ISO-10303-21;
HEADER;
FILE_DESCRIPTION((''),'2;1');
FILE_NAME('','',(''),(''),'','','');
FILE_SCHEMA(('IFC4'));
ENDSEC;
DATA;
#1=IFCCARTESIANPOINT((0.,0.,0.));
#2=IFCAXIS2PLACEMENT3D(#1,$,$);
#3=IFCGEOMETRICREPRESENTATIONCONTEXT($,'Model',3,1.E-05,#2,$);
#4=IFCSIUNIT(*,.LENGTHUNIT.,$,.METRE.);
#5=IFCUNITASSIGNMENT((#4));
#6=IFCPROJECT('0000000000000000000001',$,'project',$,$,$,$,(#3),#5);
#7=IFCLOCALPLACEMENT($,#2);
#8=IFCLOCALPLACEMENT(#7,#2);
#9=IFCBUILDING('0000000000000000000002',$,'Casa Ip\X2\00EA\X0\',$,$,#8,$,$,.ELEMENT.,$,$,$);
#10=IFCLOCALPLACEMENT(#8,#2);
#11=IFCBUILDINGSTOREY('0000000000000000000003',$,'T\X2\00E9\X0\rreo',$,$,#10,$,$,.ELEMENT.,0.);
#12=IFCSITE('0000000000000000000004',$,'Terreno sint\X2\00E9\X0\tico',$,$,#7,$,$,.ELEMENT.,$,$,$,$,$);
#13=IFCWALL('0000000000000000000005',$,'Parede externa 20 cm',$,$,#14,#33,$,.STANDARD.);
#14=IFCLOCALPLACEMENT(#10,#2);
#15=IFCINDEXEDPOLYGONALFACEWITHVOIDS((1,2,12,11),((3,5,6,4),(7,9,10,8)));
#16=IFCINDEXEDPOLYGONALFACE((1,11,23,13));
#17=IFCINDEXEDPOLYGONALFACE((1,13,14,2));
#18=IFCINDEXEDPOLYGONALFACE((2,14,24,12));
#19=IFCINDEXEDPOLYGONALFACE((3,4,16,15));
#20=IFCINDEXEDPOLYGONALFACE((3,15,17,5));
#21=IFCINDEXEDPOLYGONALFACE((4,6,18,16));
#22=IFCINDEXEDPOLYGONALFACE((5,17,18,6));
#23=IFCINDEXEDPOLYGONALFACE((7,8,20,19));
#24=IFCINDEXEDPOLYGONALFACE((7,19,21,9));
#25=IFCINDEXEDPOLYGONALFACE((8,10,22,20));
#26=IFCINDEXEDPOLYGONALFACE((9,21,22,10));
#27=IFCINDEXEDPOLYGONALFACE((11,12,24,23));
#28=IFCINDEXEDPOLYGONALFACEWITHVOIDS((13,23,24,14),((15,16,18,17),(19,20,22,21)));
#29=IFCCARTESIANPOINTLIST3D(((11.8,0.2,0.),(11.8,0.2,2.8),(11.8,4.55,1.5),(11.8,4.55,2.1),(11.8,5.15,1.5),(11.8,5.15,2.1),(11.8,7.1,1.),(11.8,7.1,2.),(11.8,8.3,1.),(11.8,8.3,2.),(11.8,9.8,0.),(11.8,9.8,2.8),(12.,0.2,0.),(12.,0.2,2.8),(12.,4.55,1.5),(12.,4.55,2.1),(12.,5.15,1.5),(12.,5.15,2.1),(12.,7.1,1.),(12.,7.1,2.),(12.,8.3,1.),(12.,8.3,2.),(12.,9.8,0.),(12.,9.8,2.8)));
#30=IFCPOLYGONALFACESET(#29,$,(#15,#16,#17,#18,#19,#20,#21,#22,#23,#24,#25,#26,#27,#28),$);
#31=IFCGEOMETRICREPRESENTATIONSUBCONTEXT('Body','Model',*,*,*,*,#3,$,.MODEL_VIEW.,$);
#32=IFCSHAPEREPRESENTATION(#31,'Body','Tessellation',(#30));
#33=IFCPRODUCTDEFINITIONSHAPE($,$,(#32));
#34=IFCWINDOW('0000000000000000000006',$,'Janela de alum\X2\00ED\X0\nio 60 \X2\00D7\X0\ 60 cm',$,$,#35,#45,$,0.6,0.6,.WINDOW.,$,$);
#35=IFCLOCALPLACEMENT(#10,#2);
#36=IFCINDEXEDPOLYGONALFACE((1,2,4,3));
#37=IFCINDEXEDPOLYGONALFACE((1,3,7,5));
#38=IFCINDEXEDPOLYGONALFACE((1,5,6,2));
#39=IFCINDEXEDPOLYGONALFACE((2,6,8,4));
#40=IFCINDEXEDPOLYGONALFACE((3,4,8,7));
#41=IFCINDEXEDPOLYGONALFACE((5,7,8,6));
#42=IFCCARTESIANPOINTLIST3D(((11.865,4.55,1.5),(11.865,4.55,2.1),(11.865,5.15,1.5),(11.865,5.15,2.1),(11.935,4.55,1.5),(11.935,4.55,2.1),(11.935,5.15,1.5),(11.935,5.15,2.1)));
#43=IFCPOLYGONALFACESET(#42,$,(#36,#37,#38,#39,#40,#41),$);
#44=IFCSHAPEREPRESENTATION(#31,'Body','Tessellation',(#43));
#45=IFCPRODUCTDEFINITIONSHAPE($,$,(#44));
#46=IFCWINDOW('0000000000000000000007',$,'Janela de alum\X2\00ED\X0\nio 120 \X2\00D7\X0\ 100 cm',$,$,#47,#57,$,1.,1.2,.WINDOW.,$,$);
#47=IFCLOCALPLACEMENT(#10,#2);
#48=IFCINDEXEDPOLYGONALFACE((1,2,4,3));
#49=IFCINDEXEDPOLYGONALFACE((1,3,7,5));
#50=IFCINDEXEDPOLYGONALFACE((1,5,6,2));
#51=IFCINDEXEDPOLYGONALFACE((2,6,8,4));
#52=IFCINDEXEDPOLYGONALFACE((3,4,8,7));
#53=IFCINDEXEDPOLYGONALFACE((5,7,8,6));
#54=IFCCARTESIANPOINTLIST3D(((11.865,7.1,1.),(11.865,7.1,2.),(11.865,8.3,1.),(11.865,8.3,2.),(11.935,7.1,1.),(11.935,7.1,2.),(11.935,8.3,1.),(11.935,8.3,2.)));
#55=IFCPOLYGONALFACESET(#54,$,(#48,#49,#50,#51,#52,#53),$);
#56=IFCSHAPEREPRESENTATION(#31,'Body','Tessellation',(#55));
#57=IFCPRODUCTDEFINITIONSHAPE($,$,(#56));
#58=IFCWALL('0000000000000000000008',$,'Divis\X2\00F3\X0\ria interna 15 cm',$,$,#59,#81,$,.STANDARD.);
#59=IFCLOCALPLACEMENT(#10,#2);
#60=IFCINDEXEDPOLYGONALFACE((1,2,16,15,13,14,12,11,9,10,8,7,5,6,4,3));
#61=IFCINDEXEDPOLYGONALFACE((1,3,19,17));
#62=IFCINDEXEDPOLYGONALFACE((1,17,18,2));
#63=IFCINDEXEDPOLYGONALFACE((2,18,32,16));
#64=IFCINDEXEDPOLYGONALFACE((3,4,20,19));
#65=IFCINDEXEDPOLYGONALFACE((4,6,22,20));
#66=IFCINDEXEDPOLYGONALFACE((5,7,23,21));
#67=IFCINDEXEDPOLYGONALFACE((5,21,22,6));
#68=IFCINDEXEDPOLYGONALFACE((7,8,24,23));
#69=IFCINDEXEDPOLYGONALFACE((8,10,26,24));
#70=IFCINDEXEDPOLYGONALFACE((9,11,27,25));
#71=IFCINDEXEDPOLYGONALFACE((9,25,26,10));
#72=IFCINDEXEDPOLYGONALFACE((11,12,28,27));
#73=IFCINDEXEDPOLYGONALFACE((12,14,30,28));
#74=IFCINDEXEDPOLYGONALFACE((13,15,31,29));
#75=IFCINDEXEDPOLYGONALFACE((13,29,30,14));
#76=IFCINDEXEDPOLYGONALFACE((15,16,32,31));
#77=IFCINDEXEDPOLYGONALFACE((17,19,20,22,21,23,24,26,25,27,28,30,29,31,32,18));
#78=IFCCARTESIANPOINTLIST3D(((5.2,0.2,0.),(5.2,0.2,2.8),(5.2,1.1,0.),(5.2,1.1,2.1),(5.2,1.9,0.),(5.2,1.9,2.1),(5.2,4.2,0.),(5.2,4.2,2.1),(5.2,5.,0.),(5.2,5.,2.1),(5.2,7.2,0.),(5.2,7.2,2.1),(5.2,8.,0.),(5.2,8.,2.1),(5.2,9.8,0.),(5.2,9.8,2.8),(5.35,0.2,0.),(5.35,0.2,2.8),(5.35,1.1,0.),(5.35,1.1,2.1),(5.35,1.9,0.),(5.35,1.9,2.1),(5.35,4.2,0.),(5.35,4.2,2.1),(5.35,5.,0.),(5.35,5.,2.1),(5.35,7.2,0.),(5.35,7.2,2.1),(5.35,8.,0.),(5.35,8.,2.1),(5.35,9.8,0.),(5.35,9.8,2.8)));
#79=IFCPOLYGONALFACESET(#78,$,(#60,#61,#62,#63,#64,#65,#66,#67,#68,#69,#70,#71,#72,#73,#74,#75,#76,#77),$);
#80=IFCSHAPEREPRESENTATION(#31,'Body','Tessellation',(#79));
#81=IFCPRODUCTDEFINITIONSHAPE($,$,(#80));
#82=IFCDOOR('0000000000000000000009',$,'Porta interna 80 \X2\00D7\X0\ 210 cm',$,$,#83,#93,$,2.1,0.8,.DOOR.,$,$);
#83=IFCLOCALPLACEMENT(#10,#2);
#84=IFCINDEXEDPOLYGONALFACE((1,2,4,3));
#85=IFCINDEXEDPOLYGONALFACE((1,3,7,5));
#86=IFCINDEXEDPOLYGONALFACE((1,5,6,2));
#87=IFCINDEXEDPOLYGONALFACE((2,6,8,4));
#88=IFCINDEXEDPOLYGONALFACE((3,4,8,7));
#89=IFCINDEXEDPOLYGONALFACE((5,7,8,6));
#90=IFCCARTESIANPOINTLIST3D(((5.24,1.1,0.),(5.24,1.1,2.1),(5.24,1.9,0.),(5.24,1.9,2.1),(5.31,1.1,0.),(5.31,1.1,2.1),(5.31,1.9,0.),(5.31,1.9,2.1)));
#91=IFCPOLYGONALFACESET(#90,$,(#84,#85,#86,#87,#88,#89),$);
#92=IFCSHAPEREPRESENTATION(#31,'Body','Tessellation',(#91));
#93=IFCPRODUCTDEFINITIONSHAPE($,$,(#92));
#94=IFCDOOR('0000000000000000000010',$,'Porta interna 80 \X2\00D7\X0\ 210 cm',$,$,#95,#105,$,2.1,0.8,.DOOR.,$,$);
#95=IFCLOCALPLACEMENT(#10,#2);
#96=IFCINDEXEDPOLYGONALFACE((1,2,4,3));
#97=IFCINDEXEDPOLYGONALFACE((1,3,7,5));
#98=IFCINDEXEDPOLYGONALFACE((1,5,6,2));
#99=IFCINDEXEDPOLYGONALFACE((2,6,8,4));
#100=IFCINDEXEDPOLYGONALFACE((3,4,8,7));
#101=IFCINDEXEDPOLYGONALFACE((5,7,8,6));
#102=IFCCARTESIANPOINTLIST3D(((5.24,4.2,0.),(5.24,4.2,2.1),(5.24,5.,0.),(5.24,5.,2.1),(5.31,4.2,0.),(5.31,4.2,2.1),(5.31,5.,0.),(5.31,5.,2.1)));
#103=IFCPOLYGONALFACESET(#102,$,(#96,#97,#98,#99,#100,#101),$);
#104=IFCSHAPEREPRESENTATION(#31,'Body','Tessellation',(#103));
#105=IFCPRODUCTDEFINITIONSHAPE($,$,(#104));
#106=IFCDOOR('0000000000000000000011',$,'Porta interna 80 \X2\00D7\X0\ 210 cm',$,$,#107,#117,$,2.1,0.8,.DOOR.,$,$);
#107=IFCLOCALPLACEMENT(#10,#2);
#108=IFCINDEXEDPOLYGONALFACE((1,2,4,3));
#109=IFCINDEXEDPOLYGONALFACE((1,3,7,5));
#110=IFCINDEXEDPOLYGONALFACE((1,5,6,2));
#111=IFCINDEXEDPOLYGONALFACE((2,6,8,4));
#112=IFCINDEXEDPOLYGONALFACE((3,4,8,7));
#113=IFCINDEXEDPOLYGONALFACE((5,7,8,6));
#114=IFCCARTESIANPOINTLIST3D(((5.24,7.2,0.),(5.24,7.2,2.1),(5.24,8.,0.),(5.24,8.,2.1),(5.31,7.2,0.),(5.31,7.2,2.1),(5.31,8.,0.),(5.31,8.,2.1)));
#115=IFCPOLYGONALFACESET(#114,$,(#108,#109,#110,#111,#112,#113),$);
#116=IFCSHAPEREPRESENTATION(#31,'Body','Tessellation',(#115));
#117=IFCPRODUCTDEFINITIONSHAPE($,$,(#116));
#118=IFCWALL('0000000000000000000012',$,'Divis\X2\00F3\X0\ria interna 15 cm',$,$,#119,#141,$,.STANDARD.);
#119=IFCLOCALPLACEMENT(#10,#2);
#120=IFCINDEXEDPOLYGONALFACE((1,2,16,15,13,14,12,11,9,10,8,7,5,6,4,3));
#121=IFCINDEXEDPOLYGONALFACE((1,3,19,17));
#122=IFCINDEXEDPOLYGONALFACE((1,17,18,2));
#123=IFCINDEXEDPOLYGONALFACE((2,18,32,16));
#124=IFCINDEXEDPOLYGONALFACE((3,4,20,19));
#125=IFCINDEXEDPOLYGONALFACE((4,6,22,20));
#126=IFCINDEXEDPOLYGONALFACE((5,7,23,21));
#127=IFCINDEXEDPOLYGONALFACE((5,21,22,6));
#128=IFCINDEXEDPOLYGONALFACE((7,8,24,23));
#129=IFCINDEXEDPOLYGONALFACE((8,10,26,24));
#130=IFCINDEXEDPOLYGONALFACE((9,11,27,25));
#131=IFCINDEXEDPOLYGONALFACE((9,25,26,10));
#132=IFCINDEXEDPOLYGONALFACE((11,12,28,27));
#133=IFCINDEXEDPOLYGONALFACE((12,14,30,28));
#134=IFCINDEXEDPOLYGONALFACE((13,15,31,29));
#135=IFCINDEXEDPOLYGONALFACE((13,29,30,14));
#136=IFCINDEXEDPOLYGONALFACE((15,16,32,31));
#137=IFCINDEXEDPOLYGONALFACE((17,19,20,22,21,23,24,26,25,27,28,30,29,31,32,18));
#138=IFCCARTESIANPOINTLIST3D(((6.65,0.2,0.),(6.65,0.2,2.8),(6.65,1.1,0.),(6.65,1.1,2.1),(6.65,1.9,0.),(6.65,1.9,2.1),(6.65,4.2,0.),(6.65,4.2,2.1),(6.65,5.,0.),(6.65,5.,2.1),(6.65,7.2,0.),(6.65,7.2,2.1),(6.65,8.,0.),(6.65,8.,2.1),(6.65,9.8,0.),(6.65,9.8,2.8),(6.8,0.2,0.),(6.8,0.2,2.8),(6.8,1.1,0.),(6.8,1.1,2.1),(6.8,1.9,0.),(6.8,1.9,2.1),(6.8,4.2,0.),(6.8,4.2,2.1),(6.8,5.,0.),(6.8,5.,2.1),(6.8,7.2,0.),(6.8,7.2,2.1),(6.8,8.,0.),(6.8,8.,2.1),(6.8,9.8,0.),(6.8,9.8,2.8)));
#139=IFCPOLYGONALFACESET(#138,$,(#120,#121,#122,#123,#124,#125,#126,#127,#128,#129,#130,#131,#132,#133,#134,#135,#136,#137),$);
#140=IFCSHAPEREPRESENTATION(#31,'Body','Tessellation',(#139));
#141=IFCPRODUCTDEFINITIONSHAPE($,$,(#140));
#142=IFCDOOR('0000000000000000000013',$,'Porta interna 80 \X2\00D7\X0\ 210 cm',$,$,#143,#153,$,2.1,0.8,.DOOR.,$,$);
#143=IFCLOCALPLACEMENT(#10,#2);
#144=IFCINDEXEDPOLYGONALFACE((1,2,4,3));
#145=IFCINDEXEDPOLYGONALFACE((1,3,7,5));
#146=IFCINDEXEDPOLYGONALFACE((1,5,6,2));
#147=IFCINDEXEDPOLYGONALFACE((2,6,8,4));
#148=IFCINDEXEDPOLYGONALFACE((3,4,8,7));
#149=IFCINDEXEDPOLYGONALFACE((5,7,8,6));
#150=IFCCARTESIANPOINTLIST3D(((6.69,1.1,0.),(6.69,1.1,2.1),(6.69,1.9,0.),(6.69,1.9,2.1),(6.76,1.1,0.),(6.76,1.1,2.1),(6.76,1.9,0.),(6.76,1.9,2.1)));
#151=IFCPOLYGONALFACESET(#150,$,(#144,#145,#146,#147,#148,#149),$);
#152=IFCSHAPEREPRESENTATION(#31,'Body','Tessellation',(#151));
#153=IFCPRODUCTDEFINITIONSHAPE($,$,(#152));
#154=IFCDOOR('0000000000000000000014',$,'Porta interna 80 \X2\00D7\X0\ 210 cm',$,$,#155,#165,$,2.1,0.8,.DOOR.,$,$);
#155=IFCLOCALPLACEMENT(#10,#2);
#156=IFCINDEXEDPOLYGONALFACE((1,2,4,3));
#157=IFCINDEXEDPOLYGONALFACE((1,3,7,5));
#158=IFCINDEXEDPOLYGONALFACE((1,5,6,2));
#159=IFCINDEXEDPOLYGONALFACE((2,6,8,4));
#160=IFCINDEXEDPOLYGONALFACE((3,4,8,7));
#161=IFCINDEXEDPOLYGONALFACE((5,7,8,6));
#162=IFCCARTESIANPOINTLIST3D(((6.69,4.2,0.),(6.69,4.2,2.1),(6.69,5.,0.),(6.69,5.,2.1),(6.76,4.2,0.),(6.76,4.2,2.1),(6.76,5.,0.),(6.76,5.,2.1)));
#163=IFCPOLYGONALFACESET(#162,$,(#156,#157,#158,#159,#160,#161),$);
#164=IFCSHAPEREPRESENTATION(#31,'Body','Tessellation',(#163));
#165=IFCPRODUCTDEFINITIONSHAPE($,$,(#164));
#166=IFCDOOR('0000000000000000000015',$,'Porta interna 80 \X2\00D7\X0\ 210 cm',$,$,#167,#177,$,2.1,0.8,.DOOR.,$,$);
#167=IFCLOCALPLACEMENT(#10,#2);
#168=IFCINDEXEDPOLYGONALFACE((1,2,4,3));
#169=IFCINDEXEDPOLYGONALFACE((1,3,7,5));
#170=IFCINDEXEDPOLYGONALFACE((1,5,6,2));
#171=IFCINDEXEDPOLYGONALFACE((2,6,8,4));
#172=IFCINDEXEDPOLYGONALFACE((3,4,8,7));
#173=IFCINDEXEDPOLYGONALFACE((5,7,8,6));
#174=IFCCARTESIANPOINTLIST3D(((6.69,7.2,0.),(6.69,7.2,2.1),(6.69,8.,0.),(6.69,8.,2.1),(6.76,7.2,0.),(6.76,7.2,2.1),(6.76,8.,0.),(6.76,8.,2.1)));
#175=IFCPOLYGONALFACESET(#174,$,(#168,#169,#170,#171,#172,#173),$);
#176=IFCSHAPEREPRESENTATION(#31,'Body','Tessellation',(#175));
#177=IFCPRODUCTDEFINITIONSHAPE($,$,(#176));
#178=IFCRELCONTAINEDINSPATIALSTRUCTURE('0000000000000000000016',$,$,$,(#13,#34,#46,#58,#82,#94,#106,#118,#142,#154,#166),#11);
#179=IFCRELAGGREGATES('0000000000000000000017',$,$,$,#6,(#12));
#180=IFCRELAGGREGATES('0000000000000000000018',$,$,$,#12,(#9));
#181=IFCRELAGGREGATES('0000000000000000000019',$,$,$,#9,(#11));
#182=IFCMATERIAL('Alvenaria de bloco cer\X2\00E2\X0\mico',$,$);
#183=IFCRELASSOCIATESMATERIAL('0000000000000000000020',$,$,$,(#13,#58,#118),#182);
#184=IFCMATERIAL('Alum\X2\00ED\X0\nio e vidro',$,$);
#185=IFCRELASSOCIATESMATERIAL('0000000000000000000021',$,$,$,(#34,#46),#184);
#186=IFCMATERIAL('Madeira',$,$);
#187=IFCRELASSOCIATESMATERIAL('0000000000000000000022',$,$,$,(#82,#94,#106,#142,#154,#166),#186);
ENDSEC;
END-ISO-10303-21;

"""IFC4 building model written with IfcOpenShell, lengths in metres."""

from ifc_helpers import new_model, si_unit, frame, frame_2d, origin, place, context, subcontext, project, spatial, rectangle, extrude, material, element, fill, save


model = new_model("IFC4")

# Units and contexts
model_context = context("Model", 3, precision=1e-05, world=origin())
body_context = subcontext(model_context, "Body", "Model", "MODEL_VIEW")
ifc_project = project(units=[si_unit("LENGTHUNIT", "METRE")], contexts=[model_context])

# Site, building, storey
site_placement = place(None, origin())
site = spatial("IfcSite", under=ifc_project, at=site_placement, Name="Terreno sintético", CompositionType="ELEMENT")
building_placement = place(site_placement, origin())
building = spatial("IfcBuilding", under=site, at=building_placement, Name="Casa Ipê", CompositionType="ELEMENT")
storey_placement = place(building_placement, origin())
storey = spatial("IfcBuildingStorey", under=building, at=storey_placement, Name="Térreo", CompositionType="ELEMENT", Elevation=0.0)

# Wall, openings, windows
ifc_material_1 = material(Name="Alvenaria de bloco cerâmico")
wall_1_placement = place(storey_placement, frame((11.8, 0.2, 0.0)))
wall_1 = element("IfcWall", 1, at=wall_1_placement, inside=storey, material=ifc_material_1, Name="Parede externa 20 cm", PredefinedType="STANDARD", context=body_context, shape_type="SweptSolid", body=[
    extrude(rectangle(XDim=0.2, YDim=9.6, at=frame_2d((0.1, 4.8))), origin(), (0.0, 0.0, 1.0), 2.8),
])
opening_1_placement = place(wall_1_placement, frame((-0.01, 4.35, 1.5)))
opening_1 = element("IfcOpeningElement", 2, at=opening_1_placement, cuts=wall_1, PredefinedType="OPENING", context=body_context, shape_type="SweptSolid", body=[
    extrude(rectangle(XDim=0.22, YDim=0.6, at=frame_2d((0.11, 0.3))), origin(), (0.0, 0.0, 1.0), 0.6),
])
opening_2_placement = place(wall_1_placement, frame((-0.01, 6.9, 1.0)))
opening_2 = element("IfcOpeningElement", 3, at=opening_2_placement, cuts=wall_1, PredefinedType="OPENING", context=body_context, shape_type="SweptSolid", body=[
    extrude(rectangle(XDim=0.22, YDim=1.2, at=frame_2d((0.11, 0.6))), origin(), (0.0, 0.0, 1.0), 1.0),
])
ifc_material_2 = material(Name="Alumínio e vidro")
window_1_placement = place(storey_placement, frame((11.865, 4.55, 1.5)))
window_1 = element("IfcWindow", 4, at=window_1_placement, inside=storey, material=ifc_material_2, Name="Janela de alumínio 60 × 60 cm", OverallHeight=0.6, OverallWidth=0.6, PredefinedType="WINDOW", context=body_context, shape_type="SweptSolid", body=[
    extrude(rectangle(XDim=0.07, YDim=0.6, at=frame_2d((0.035, 0.3))), origin(), (0.0, 0.0, 1.0), 0.6),
])
fill(opening_1, window_1)
window_2_placement = place(storey_placement, frame((11.865, 7.1, 1.0)))
window_2 = element("IfcWindow", 5, at=window_2_placement, inside=storey, material=ifc_material_2, Name="Janela de alumínio 120 × 100 cm", OverallHeight=1.0, OverallWidth=1.2, PredefinedType="WINDOW", context=body_context, shape_type="SweptSolid", body=[
    extrude(rectangle(XDim=0.07, YDim=1.2, at=frame_2d((0.035, 0.6))), origin(), (0.0, 0.0, 1.0), 1.0),
])
fill(opening_2, window_2)

# Walls, openings, doors
wall_2_placement = place(storey_placement, frame((5.2, 0.2, 0.0)))
wall_2 = element("IfcWall", 6, at=wall_2_placement, inside=storey, material=ifc_material_1, Name="Divisória interna 15 cm", PredefinedType="STANDARD", context=body_context, shape_type="SweptSolid", body=[
    extrude(rectangle(XDim=0.15, YDim=9.6, at=frame_2d((0.075, 4.8))), origin(), (0.0, 0.0, 1.0), 2.8),
])
opening_3_placement = place(wall_2_placement, frame((-0.01, 0.9, 0.0)))
opening_3 = element("IfcOpeningElement", 7, at=opening_3_placement, cuts=wall_2, PredefinedType="OPENING", context=body_context, shape_type="SweptSolid", body=[
    extrude(rectangle(XDim=0.17, YDim=0.8, at=frame_2d((0.085, 0.4))), origin(), (0.0, 0.0, 1.0), 2.1),
])
opening_4_placement = place(wall_2_placement, frame((-0.01, 4.0, 0.0)))
opening_4 = element("IfcOpeningElement", 8, at=opening_4_placement, cuts=wall_2, PredefinedType="OPENING", context=body_context, shape_type="SweptSolid", body=[
    extrude(rectangle(XDim=0.17, YDim=0.8, at=frame_2d((0.085, 0.4))), origin(), (0.0, 0.0, 1.0), 2.1),
])
opening_5_placement = place(wall_2_placement, frame((-0.01, 7.0, 0.0)))
opening_5 = element("IfcOpeningElement", 9, at=opening_5_placement, cuts=wall_2, PredefinedType="OPENING", context=body_context, shape_type="SweptSolid", body=[
    extrude(rectangle(XDim=0.17, YDim=0.8, at=frame_2d((0.085, 0.4))), origin(), (0.0, 0.0, 1.0), 2.1),
])
ifc_material_3 = material(Name="Madeira")
door_1_placement = place(storey_placement, frame((5.24, 1.1, 0.0)))
door_1 = element("IfcDoor", 10, at=door_1_placement, inside=storey, material=ifc_material_3, Name="Porta interna 80 × 210 cm", OverallHeight=2.1, OverallWidth=0.8, PredefinedType="DOOR", context=body_context, shape_type="SweptSolid", body=[
    extrude(rectangle(XDim=0.07, YDim=0.8, at=frame_2d((0.035, 0.4))), origin(), (0.0, 0.0, 1.0), 2.1),
])
fill(opening_3, door_1)
door_2_placement = place(storey_placement, frame((5.24, 4.2, 0.0)))
door_2 = element("IfcDoor", 11, at=door_2_placement, inside=storey, material=ifc_material_3, Name="Porta interna 80 × 210 cm", OverallHeight=2.1, OverallWidth=0.8, PredefinedType="DOOR", context=body_context, shape_type="SweptSolid", body=[
    extrude(rectangle(XDim=0.07, YDim=0.8, at=frame_2d((0.035, 0.4))), origin(), (0.0, 0.0, 1.0), 2.1),
])
fill(opening_4, door_2)
door_3_placement = place(storey_placement, frame((5.24, 7.2, 0.0)))
door_3 = element("IfcDoor", 12, at=door_3_placement, inside=storey, material=ifc_material_3, Name="Porta interna 80 × 210 cm", OverallHeight=2.1, OverallWidth=0.8, PredefinedType="DOOR", context=body_context, shape_type="SweptSolid", body=[
    extrude(rectangle(XDim=0.07, YDim=0.8, at=frame_2d((0.035, 0.4))), origin(), (0.0, 0.0, 1.0), 2.1),
])
fill(opening_5, door_3)
wall_3_placement = place(storey_placement, frame((6.65, 0.2, 0.0)))
wall_3 = element("IfcWall", 13, at=wall_3_placement, inside=storey, material=ifc_material_1, Name="Divisória interna 15 cm", PredefinedType="STANDARD", context=body_context, shape_type="SweptSolid", body=[
    extrude(rectangle(XDim=0.15, YDim=9.6, at=frame_2d((0.075, 4.8))), origin(), (0.0, 0.0, 1.0), 2.8),
])
opening_6_placement = place(wall_3_placement, frame((-0.01, 0.9, 0.0)))
opening_6 = element("IfcOpeningElement", 14, at=opening_6_placement, cuts=wall_3, PredefinedType="OPENING", context=body_context, shape_type="SweptSolid", body=[
    extrude(rectangle(XDim=0.17, YDim=0.8, at=frame_2d((0.085, 0.4))), origin(), (0.0, 0.0, 1.0), 2.1),
])
opening_7_placement = place(wall_3_placement, frame((-0.01, 4.0, 0.0)))
opening_7 = element("IfcOpeningElement", 15, at=opening_7_placement, cuts=wall_3, PredefinedType="OPENING", context=body_context, shape_type="SweptSolid", body=[
    extrude(rectangle(XDim=0.17, YDim=0.8, at=frame_2d((0.085, 0.4))), origin(), (0.0, 0.0, 1.0), 2.1),
])
opening_8_placement = place(wall_3_placement, frame((-0.01, 7.0, 0.0)))
opening_8 = element("IfcOpeningElement", 16, at=opening_8_placement, cuts=wall_3, PredefinedType="OPENING", context=body_context, shape_type="SweptSolid", body=[
    extrude(rectangle(XDim=0.17, YDim=0.8, at=frame_2d((0.085, 0.4))), origin(), (0.0, 0.0, 1.0), 2.1),
])
door_4_placement = place(storey_placement, frame((6.69, 1.1, 0.0)))
door_4 = element("IfcDoor", 17, at=door_4_placement, inside=storey, material=ifc_material_3, Name="Porta interna 80 × 210 cm", OverallHeight=2.1, OverallWidth=0.8, PredefinedType="DOOR", context=body_context, shape_type="SweptSolid", body=[
    extrude(rectangle(XDim=0.07, YDim=0.8, at=frame_2d((0.035, 0.4))), origin(), (0.0, 0.0, 1.0), 2.1),
])
fill(opening_6, door_4)
door_5_placement = place(storey_placement, frame((6.69, 4.2, 0.0)))
door_5 = element("IfcDoor", 18, at=door_5_placement, inside=storey, material=ifc_material_3, Name="Porta interna 80 × 210 cm", OverallHeight=2.1, OverallWidth=0.8, PredefinedType="DOOR", context=body_context, shape_type="SweptSolid", body=[
    extrude(rectangle(XDim=0.07, YDim=0.8, at=frame_2d((0.035, 0.4))), origin(), (0.0, 0.0, 1.0), 2.1),
])
fill(opening_7, door_5)
door_6_placement = place(storey_placement, frame((6.69, 7.2, 0.0)))
door_6 = element("IfcDoor", 19, at=door_6_placement, inside=storey, material=ifc_material_3, Name="Porta interna 80 × 210 cm", OverallHeight=2.1, OverallWidth=0.8, PredefinedType="DOOR", context=body_context, shape_type="SweptSolid", body=[
    extrude(rectangle(XDim=0.07, YDim=0.8, at=frame_2d((0.035, 0.4))), origin(), (0.0, 0.0, 1.0), 2.1),
])
fill(opening_8, door_6)

save(model, "model.ifc")
